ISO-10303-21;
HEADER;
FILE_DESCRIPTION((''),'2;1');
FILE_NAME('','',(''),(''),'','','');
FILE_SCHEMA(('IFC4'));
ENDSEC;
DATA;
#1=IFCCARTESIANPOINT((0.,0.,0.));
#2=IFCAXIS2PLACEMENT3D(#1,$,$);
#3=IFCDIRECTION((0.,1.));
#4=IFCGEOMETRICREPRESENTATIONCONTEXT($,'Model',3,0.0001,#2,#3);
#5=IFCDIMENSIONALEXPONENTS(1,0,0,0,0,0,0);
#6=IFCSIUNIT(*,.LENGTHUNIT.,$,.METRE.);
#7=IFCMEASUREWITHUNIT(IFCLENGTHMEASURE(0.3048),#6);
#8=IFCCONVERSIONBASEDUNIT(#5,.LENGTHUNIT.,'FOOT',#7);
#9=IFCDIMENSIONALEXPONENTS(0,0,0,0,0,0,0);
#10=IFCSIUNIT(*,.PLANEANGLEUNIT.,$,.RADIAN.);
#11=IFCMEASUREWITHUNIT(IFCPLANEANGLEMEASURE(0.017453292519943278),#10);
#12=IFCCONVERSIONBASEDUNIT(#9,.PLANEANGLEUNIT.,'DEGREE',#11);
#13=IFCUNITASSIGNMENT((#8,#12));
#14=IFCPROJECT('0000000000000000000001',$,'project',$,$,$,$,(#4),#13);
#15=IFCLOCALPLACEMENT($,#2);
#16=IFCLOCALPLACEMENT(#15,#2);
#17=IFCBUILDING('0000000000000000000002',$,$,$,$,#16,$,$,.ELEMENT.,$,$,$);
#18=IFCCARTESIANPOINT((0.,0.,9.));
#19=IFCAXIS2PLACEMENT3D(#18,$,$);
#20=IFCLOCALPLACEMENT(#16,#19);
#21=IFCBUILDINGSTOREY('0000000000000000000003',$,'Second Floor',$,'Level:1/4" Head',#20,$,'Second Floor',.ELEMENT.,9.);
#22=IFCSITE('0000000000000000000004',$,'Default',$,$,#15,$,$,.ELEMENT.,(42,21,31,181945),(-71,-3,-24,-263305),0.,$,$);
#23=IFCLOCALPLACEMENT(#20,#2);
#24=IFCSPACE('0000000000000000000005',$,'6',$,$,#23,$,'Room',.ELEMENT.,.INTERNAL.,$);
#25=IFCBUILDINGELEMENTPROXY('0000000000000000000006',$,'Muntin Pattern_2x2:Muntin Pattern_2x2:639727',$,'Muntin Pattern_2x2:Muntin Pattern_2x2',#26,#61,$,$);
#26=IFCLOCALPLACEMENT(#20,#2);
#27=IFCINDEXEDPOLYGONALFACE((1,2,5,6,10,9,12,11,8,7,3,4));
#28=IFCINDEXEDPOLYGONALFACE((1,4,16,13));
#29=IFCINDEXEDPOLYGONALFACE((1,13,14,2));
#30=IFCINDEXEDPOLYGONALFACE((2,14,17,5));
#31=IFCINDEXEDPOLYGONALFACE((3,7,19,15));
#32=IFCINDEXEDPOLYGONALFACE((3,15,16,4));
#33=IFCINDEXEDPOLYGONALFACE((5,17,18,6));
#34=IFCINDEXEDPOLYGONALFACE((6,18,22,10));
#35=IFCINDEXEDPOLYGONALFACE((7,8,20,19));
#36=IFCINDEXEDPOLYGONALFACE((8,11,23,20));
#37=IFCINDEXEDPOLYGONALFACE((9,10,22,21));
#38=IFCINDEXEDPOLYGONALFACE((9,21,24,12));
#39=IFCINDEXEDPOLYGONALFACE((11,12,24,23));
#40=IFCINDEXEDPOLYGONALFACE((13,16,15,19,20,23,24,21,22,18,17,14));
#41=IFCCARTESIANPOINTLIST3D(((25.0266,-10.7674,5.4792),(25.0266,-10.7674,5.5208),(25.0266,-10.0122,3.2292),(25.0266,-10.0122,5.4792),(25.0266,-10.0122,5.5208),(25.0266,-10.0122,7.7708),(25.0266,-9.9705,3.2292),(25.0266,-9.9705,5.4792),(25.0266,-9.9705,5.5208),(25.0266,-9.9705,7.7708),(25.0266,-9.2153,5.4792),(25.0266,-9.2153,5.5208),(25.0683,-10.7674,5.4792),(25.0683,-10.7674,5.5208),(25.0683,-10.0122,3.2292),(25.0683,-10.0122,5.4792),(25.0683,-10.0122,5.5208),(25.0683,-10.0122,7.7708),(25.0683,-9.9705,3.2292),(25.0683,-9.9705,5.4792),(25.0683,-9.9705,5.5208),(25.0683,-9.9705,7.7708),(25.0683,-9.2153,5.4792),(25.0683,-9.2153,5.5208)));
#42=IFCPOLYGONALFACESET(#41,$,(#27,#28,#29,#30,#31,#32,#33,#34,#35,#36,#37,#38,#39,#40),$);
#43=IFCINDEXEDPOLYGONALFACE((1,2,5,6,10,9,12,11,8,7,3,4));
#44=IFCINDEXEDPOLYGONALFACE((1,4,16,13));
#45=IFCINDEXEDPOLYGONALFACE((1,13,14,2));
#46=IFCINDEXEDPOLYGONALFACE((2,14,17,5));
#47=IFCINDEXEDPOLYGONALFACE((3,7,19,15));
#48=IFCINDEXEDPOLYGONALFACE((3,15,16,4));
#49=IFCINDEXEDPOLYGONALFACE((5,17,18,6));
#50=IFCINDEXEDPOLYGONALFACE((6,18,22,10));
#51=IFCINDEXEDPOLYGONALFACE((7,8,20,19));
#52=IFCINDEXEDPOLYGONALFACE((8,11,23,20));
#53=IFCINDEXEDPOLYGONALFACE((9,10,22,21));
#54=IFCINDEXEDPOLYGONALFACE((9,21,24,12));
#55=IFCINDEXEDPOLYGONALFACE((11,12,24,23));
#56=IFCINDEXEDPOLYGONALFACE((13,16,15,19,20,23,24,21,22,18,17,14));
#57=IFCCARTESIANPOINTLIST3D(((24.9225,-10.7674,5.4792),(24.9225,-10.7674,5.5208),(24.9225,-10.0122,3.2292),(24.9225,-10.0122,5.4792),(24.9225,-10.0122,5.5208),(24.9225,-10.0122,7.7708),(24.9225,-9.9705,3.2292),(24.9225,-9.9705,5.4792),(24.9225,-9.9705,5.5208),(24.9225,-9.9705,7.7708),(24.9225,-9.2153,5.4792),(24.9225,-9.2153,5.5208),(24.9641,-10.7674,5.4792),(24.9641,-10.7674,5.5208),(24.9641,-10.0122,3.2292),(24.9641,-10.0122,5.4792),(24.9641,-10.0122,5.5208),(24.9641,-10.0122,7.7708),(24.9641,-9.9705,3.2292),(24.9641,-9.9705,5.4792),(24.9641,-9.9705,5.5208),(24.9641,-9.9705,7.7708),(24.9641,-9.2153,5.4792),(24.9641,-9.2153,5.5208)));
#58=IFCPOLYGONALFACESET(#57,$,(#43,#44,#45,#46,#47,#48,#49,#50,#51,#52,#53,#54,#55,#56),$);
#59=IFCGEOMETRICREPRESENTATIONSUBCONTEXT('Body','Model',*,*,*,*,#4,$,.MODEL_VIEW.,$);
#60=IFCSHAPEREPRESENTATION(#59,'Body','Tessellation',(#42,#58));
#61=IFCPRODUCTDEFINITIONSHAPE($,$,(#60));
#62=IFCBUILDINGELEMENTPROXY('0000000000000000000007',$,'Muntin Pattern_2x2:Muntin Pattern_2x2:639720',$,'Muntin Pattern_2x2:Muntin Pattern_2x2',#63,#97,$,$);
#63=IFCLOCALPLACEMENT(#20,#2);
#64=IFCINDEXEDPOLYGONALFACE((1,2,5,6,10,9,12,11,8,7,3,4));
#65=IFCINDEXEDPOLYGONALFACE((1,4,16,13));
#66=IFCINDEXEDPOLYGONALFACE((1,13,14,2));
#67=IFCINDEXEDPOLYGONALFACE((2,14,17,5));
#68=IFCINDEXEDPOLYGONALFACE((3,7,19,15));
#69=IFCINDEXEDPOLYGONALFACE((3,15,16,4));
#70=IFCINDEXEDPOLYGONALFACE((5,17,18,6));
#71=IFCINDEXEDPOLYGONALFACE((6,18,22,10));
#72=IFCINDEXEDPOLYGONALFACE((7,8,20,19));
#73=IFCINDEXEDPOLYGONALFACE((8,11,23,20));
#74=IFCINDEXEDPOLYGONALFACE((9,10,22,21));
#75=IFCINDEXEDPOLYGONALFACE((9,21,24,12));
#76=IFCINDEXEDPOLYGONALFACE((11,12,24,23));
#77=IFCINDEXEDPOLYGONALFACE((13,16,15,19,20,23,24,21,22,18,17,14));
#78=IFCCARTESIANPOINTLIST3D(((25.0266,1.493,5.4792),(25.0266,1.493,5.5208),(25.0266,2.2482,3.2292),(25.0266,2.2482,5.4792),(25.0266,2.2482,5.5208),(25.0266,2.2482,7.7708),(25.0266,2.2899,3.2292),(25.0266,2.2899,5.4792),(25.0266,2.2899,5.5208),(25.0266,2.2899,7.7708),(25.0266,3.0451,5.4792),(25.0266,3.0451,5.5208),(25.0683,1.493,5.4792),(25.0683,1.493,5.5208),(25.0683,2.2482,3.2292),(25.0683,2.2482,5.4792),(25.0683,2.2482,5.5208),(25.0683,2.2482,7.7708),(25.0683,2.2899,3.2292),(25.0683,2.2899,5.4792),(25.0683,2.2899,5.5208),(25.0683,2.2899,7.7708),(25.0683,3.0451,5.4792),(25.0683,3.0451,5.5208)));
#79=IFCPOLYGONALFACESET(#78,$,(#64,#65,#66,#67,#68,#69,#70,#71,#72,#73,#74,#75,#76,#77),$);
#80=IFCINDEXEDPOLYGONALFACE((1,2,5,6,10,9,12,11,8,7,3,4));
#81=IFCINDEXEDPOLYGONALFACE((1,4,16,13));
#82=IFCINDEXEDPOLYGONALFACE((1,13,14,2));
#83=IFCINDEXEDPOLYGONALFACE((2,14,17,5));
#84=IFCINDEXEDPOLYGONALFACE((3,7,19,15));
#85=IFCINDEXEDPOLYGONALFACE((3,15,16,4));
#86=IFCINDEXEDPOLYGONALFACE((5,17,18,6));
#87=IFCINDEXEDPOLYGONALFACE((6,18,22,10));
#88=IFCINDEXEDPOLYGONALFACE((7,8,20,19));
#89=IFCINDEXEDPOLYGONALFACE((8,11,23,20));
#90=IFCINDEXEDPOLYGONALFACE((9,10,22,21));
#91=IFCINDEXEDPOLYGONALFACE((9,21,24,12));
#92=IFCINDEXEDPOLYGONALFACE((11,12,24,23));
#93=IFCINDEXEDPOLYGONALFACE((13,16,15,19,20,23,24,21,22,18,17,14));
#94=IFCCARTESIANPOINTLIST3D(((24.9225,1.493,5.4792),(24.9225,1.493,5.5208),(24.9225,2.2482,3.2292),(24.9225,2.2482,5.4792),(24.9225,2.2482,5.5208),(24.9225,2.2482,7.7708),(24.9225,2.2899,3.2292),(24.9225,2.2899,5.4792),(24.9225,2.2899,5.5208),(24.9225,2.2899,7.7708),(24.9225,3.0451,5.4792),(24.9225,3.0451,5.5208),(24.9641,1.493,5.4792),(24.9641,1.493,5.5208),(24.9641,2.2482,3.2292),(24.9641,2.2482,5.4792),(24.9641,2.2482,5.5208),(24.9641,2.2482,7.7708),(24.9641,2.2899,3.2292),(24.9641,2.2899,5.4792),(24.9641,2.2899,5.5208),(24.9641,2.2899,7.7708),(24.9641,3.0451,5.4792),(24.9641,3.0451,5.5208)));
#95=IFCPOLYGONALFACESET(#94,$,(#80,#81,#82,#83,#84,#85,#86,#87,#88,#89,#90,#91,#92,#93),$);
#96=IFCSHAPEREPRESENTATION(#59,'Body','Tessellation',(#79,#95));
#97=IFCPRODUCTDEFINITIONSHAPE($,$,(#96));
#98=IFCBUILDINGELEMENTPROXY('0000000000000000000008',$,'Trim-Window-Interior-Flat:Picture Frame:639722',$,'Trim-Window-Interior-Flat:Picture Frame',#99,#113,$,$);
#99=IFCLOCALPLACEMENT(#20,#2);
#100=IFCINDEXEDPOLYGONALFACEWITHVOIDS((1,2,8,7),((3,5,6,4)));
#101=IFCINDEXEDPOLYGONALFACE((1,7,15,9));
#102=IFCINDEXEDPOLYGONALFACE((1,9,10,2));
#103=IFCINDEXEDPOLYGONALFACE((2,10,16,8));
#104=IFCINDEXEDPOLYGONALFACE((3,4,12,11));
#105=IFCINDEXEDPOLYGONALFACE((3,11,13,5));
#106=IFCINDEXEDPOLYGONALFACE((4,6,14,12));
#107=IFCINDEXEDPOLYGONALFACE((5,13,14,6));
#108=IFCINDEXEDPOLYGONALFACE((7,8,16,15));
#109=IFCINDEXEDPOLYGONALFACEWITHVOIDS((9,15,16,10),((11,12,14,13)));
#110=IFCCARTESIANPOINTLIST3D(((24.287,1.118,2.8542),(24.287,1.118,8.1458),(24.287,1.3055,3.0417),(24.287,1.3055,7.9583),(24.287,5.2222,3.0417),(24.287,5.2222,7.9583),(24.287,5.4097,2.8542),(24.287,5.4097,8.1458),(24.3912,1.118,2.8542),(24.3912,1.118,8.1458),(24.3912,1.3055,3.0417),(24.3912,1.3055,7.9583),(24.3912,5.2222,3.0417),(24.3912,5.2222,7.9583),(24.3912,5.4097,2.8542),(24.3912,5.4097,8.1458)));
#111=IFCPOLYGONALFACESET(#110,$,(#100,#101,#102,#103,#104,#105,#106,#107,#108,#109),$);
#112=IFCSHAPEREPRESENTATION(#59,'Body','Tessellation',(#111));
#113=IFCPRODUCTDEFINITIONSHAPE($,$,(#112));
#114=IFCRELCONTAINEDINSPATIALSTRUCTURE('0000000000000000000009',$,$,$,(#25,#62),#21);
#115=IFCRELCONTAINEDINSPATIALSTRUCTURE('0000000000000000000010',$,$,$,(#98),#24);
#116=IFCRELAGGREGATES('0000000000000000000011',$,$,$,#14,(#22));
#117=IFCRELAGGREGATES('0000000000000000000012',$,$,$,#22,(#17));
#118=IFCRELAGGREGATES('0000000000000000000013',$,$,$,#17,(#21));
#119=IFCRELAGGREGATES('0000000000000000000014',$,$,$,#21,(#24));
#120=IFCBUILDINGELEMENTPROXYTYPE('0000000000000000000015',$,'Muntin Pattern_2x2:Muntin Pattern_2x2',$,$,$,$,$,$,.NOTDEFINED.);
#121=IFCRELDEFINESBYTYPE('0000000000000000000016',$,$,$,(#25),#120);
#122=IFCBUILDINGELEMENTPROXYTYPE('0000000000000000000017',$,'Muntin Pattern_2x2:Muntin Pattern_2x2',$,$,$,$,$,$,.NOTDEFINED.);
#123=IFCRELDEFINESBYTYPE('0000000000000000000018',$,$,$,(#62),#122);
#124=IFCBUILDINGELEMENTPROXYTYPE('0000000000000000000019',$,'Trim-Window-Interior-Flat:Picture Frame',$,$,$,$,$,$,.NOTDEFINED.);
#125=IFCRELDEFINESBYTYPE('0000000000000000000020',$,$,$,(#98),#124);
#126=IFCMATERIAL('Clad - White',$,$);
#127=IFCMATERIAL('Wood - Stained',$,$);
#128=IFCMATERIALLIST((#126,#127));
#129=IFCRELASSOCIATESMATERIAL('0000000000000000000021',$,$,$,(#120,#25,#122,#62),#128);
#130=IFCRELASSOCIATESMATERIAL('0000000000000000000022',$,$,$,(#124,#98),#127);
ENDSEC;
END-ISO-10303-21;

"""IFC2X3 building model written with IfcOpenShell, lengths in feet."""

from ifc_helpers import new_model, entity, si_unit, converted_unit, direction, frame, origin, place, context, subcontext, project, spatial, polyline, outline, extrude, source, transform, mapped, material, material_list, type_object, type_shapes, element, save


model = new_model("IFC2X3")

# Units and contexts
model_context = context("Model", 3, precision=0.0001, world=origin(), true_north=direction((0.0, 1.0)))
body_context = subcontext(model_context, "Body", "Model", "MODEL_VIEW")
ifc_project = project(units=[converted_unit("LENGTHUNIT", "FOOT", entity("IfcLengthMeasure", 0.3048), si_unit("LENGTHUNIT", "METRE"), dimensions=[1, 0, 0, 0, 0, 0, 0]), converted_unit("PLANEANGLEUNIT", "DEGREE", entity("IfcPlaneAngleMeasure", 0.017453292519943278), si_unit("PLANEANGLEUNIT", "RADIAN"), dimensions=[0, 0, 0, 0, 0, 0, 0])], contexts=[model_context])

# Site, building, storey
site_placement = place(None, origin())
site = spatial("IfcSite", under=ifc_project, at=site_placement, Name="Default", CompositionType="ELEMENT", RefLatitude=(42, 21, 31, 181945), RefLongitude=(-71, -3, -24, -263305), RefElevation=0.0)
building_placement = place(site_placement, origin())
building = spatial("IfcBuilding", under=site, at=building_placement, CompositionType="ELEMENT")
storey_placement = place(building_placement, frame((0.0, 0.0, 9.0)))
storey = spatial("IfcBuildingStorey", under=building, at=storey_placement, Name="Second Floor", ObjectType="Level:1/4\" Head", LongName="Second Floor", CompositionType="ELEMENT", Elevation=9.0)

# Shared definitions
space_placement = place(storey_placement, origin())
space = spatial("IfcSpace", under=storey, at=space_placement, Name="6", LongName="Room", CompositionType="ELEMENT", InteriorOrExteriorSpace="INTERNAL")

# Building element proxies
ifc_material_1 = material(Name="Clad - White")
ifc_material_2 = material(Name="Wood - Stained")
ifc_material_list_1 = material_list([ifc_material_1, ifc_material_2])
building_element_proxy_type_1 = type_object("IfcBuildingElementProxyType", Name="Muntin Pattern_2x2:Muntin Pattern_2x2", PredefinedType="NOTDEFINED", material=ifc_material_list_1)
shared_shape_1 = source(origin(), body_context, "Body", "SweptSolid", [
    extrude(outline(polyline([(0.0208, -0.0208), (2.2708, -0.0208), (2.2708, 0.0208), (0.0208, 0.0208), (0.0208, 0.776), (-0.0208, 0.776), (-0.0208, 0.0208), (-2.2708, 0.0208), (-2.2708, -0.0208), (-0.0208, -0.0208), (-0.0208, -0.776), (0.0208, -0.776), (0.0208, -0.0208)])), frame((0.0, 0.0313, 2.2708), z_axis=(0.0, 1.0, 0.0), x_axis=(0.0, 0.0, 1.0)), (0.0, 0.0, 1.0), 0.0417),
    extrude(outline(polyline([(0.0208, -0.0208), (2.2708, -0.0208), (2.2708, 0.0208), (0.0208, 0.0208), (0.0208, 0.776), (-0.0208, 0.776), (-0.0208, 0.0208), (-2.2708, 0.0208), (-2.2708, -0.0208), (-0.0208, -0.0208), (-0.0208, -0.776), (0.0208, -0.776), (0.0208, -0.0208)])), frame((0.0, -0.0729, 2.2708), z_axis=(0.0, 1.0, 0.0), x_axis=(0.0, 0.0, 1.0)), (0.0, 0.0, 1.0), 0.0417),
])
type_shapes(building_element_proxy_type_1, [shared_shape_1])
for number, where, z_axis, x_axis, name in (
    (1, (24.9954, -9.9913, 3.2292), (0.0, 0.0, 1.0), (0.0, -1.0, 0.0), "Muntin Pattern_2x2:Muntin Pattern_2x2:639727"),
):
    element("IfcBuildingElementProxy", number, at=place(storey_placement, frame(where, z_axis=z_axis, x_axis=x_axis)), inside=storey, type_object=building_element_proxy_type_1, material=ifc_material_list_1, Name=name, ObjectType="Muntin Pattern_2x2:Muntin Pattern_2x2", context=body_context, shape_type="MappedRepresentation", body=[
        mapped(shared_shape_1, transform((0.0, 0.0, 0.0), scale=1.0)),
    ])
building_element_proxy_type_2 = type_object("IfcBuildingElementProxyType", Name="Muntin Pattern_2x2:Muntin Pattern_2x2", PredefinedType="NOTDEFINED", material=ifc_material_list_1)
shared_shape_2 = source(origin(), body_context, "Body", "SweptSolid", [
    extrude(outline(polyline([(0.0208, -0.0208), (2.2708, -0.0208), (2.2708, 0.0208), (0.0208, 0.0208), (0.0208, 0.776), (-0.0208, 0.776), (-0.0208, 0.0208), (-2.2708, 0.0208), (-2.2708, -0.0208), (-0.0208, -0.0208), (-0.0208, -0.776), (0.0208, -0.776), (0.0208, -0.0208)])), frame((0.0, -0.0729, 2.2708), z_axis=(0.0, 1.0, 0.0), x_axis=(0.0, 0.0, 1.0)), (0.0, 0.0, 1.0), 0.0417),
    extrude(outline(polyline([(0.0208, -0.0208), (2.2708, -0.0208), (2.2708, 0.0208), (0.0208, 0.0208), (0.0208, 0.776), (-0.0208, 0.776), (-0.0208, 0.0208), (-2.2708, 0.0208), (-2.2708, -0.0208), (-0.0208, -0.0208), (-0.0208, -0.776), (0.0208, -0.776), (0.0208, -0.0208)])), frame((0.0, 0.0313, 2.2708), z_axis=(0.0, 1.0, 0.0), x_axis=(0.0, 0.0, 1.0)), (0.0, 0.0, 1.0), 0.0417),
])
type_shapes(building_element_proxy_type_2, [shared_shape_2])
proxy_1_placement = place(storey_placement, frame((24.9954, 2.2691, 3.2292), z_axis=(0.0, 0.0, 1.0), x_axis=(0.0, 1.0, 0.0)))
element("IfcBuildingElementProxy", 2, at=proxy_1_placement, inside=storey, type_object=building_element_proxy_type_2, material=ifc_material_list_1, Name="Muntin Pattern_2x2:Muntin Pattern_2x2:639720", ObjectType="Muntin Pattern_2x2:Muntin Pattern_2x2", context=body_context, shape_type="MappedRepresentation", body=[
    mapped(shared_shape_2, transform((0.0, 0.0, 0.0), scale=1.0)),
])
building_element_proxy_type_3 = type_object("IfcBuildingElementProxyType", Name="Trim-Window-Interior-Flat:Picture Frame", PredefinedType="NOTDEFINED", material=ifc_material_2)
shared_shape_3 = source(origin(), body_context, "Body", "SweptSolid", [
    extrude(outline(polyline([(-2.1458, -2.6458), (2.1458, -2.6458), (2.1458, 2.6458), (-2.1458, 2.6458), (-2.1458, -2.6458)]), holes=[polyline([(-1.9583, -2.4583), (-1.9583, 2.4583), (1.9583, 2.4583), (1.9583, -2.4583), (-1.9583, -2.4583)])]), frame((0.0, -2.5, 0.0), z_axis=(0.0, 0.0, 1.0), x_axis=(-1.0, 0.0, 0.0)), (0.0, 0.0, 1.0), 0.1042),
])
type_shapes(building_element_proxy_type_3, [shared_shape_3])
proxy_2_placement = place(space_placement, frame((24.3912, 3.2639, 8.0), z_axis=(-1.0, 0.0, 0.0), x_axis=(0.0, -1.0, 0.0)))
element("IfcBuildingElementProxy", 3, at=proxy_2_placement, inside=space, type_object=building_element_proxy_type_3, material=ifc_material_2, Name="Trim-Window-Interior-Flat:Picture Frame:639722", ObjectType="Trim-Window-Interior-Flat:Picture Frame", context=body_context, shape_type="MappedRepresentation", body=[
    mapped(shared_shape_3, transform((0.0, 0.0, 0.0), scale=1.0)),
])

save(model, "model.ifc")
